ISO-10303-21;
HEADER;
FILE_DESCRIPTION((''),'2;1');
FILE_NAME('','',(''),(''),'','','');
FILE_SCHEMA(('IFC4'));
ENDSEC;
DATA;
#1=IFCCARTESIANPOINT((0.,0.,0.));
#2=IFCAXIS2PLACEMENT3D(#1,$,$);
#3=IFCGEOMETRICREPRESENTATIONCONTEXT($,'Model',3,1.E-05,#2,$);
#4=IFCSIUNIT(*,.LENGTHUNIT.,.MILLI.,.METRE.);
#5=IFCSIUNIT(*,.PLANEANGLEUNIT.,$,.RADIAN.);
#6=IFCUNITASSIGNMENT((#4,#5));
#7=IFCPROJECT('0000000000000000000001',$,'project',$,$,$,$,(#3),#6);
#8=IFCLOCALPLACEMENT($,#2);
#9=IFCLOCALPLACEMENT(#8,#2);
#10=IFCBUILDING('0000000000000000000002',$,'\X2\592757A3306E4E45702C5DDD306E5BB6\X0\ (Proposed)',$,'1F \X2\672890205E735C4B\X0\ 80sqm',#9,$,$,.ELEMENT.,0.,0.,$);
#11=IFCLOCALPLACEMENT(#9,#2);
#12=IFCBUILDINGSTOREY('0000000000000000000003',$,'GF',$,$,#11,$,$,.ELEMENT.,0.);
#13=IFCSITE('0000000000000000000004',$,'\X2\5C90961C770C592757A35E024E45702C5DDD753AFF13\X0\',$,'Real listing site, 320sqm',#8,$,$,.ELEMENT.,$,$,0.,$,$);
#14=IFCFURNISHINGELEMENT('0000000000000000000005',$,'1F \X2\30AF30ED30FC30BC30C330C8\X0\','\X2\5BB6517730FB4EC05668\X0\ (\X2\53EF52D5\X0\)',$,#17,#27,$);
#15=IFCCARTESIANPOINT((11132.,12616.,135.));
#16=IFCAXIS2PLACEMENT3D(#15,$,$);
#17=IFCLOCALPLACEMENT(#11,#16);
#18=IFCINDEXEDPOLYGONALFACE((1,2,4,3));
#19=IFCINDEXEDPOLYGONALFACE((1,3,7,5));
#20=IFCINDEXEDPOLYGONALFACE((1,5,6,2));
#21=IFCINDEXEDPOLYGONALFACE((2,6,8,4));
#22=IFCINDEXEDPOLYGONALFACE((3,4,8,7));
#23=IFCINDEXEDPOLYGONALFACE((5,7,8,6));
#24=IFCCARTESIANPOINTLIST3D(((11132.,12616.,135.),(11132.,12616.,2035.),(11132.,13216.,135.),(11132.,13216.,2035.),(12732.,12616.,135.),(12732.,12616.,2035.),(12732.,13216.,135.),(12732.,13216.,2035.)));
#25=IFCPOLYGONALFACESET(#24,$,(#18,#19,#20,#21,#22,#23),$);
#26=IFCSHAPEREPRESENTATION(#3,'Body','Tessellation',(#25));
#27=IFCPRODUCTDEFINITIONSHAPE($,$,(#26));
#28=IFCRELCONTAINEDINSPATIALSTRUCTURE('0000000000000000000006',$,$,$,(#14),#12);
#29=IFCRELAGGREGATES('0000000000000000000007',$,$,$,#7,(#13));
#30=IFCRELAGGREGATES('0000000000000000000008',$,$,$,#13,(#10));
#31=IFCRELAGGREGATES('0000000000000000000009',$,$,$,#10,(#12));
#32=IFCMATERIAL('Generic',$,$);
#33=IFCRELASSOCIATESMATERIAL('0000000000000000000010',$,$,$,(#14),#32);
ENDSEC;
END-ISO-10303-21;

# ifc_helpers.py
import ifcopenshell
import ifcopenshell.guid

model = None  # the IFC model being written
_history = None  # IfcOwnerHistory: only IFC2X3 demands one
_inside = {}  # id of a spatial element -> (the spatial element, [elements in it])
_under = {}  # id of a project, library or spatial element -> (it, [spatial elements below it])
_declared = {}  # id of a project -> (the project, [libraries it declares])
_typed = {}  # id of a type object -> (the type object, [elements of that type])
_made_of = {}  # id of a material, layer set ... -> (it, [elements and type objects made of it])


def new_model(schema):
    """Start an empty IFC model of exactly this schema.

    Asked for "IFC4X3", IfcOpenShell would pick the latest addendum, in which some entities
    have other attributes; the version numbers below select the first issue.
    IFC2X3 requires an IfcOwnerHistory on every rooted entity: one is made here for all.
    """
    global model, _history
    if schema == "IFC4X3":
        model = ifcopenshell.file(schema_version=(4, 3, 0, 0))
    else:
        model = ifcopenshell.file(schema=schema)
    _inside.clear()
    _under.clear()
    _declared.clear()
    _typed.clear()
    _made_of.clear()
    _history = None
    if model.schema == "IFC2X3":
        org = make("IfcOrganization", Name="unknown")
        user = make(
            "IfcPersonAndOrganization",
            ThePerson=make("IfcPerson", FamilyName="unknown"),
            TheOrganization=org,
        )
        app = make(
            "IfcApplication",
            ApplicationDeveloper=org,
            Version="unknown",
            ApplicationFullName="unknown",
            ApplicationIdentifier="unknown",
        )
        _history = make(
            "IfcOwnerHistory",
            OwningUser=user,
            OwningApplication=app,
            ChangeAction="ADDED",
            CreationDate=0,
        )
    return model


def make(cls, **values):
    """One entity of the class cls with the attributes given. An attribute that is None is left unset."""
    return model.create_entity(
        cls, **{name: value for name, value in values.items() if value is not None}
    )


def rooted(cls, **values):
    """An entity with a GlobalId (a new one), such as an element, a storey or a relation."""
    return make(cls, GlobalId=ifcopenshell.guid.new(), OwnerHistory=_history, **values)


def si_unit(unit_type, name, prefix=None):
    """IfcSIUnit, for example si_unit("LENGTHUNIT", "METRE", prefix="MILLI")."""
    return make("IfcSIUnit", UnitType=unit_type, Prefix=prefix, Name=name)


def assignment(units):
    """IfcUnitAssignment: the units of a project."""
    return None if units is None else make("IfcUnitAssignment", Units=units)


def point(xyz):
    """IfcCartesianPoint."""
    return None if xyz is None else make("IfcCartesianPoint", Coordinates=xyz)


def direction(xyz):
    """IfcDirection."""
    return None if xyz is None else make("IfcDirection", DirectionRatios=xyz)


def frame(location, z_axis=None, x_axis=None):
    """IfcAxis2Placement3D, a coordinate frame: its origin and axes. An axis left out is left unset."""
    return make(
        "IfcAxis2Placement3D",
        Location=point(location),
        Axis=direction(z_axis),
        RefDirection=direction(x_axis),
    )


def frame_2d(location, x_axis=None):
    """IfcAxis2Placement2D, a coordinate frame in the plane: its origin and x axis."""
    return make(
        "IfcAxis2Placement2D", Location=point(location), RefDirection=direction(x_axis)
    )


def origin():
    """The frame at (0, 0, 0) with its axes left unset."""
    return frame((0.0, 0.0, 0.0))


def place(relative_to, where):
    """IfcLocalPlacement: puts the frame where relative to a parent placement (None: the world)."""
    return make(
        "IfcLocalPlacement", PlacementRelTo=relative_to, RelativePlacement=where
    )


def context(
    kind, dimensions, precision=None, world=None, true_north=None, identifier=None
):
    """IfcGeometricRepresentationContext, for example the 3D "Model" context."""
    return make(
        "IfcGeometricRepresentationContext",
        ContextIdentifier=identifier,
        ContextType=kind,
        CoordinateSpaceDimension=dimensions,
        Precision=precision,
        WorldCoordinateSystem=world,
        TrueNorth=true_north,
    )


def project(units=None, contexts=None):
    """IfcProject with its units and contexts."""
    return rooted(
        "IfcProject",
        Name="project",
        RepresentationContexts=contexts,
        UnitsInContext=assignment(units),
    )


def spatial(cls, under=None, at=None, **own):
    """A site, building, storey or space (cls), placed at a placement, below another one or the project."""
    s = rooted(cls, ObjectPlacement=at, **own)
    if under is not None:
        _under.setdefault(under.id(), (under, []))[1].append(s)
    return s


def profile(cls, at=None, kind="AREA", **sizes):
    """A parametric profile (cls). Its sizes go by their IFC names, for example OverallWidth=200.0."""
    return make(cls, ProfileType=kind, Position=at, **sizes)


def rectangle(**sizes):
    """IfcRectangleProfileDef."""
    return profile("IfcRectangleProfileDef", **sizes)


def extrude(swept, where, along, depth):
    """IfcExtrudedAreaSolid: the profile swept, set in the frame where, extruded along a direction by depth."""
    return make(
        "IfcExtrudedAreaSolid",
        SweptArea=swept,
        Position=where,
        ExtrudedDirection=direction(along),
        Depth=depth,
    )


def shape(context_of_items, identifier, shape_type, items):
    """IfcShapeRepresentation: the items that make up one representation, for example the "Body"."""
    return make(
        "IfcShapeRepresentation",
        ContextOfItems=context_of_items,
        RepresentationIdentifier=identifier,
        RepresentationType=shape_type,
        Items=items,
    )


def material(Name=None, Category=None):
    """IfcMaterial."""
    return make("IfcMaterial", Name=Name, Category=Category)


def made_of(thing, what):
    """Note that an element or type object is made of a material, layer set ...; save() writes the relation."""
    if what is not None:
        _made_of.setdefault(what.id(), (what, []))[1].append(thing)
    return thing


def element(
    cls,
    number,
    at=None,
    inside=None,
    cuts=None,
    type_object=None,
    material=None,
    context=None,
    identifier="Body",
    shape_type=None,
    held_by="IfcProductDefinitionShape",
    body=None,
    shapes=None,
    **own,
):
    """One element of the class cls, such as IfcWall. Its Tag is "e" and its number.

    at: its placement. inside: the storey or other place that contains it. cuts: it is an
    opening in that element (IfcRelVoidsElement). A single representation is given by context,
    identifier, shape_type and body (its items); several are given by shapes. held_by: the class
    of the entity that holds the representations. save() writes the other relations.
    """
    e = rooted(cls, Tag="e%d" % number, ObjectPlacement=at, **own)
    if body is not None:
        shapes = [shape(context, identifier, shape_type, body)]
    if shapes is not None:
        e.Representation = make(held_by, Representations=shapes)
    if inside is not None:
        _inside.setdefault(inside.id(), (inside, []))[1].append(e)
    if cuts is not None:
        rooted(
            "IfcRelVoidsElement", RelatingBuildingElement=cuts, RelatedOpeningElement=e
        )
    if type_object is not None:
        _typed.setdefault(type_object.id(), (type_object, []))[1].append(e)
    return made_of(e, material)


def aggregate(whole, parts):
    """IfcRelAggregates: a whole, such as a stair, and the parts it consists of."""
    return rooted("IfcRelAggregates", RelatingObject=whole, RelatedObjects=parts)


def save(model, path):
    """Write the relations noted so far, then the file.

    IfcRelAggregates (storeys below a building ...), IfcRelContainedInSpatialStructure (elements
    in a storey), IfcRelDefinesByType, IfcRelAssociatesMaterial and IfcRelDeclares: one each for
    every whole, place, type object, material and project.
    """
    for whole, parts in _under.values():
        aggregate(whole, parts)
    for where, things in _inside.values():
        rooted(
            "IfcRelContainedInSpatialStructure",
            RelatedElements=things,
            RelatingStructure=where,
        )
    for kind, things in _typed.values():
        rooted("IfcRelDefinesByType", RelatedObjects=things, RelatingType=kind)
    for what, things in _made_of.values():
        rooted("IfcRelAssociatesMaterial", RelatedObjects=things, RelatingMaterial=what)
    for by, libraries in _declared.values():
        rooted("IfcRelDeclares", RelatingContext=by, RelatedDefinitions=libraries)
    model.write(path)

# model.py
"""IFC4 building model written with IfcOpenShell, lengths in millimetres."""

from ifc_helpers import new_model, si_unit, frame, frame_2d, origin, place, context, project, spatial, rectangle, extrude, material, element, save


model = new_model("IFC4")

# Units and contexts
model_context = context("Model", 3, precision=1e-05, world=origin())
ifc_project = project(units=[si_unit("LENGTHUNIT", "METRE", prefix="MILLI"), si_unit("PLANEANGLEUNIT", "RADIAN")], contexts=[model_context])

# Site, building, storey
site_placement = place(None, origin())
site = spatial("IfcSite", under=ifc_project, at=site_placement, Name="岐阜県大垣市久瀬川町３", ObjectType="Real listing site, 320sqm", CompositionType="ELEMENT", RefElevation=0.0)
building_placement = place(site_placement, origin())
building = spatial("IfcBuilding", under=site, at=building_placement, Name="大垣の久瀬川の家 (Proposed)", ObjectType="1F 木造平屋 80sqm", CompositionType="ELEMENT", ElevationOfRefHeight=0.0, ElevationOfTerrain=0.0)
storey_placement = place(building_placement, origin())
storey = spatial("IfcBuildingStorey", under=building, at=storey_placement, Name="GF", CompositionType="ELEMENT", Elevation=0.0)

# Shared definitions
ifc_material_1 = material(Name="Generic")

# Furnishing element
furnishing_placement = place(storey_placement, frame((11132.0, 12616.0, 135.0)))
element("IfcFurnishingElement", 1, at=furnishing_placement, inside=storey, material=ifc_material_1, Name="1F クローゼット", Description="家具・什器 (可動)", context=model_context, shape_type="SweptSolid", body=[
    extrude(rectangle(XDim=1600.0, YDim=600.0, at=frame_2d((800.0, 300.0))), frame((11132.0, 12616.0, 135.0)), (0.0, 0.0, 1.0), 1900.0),
])

save(model, "model.ifc")
